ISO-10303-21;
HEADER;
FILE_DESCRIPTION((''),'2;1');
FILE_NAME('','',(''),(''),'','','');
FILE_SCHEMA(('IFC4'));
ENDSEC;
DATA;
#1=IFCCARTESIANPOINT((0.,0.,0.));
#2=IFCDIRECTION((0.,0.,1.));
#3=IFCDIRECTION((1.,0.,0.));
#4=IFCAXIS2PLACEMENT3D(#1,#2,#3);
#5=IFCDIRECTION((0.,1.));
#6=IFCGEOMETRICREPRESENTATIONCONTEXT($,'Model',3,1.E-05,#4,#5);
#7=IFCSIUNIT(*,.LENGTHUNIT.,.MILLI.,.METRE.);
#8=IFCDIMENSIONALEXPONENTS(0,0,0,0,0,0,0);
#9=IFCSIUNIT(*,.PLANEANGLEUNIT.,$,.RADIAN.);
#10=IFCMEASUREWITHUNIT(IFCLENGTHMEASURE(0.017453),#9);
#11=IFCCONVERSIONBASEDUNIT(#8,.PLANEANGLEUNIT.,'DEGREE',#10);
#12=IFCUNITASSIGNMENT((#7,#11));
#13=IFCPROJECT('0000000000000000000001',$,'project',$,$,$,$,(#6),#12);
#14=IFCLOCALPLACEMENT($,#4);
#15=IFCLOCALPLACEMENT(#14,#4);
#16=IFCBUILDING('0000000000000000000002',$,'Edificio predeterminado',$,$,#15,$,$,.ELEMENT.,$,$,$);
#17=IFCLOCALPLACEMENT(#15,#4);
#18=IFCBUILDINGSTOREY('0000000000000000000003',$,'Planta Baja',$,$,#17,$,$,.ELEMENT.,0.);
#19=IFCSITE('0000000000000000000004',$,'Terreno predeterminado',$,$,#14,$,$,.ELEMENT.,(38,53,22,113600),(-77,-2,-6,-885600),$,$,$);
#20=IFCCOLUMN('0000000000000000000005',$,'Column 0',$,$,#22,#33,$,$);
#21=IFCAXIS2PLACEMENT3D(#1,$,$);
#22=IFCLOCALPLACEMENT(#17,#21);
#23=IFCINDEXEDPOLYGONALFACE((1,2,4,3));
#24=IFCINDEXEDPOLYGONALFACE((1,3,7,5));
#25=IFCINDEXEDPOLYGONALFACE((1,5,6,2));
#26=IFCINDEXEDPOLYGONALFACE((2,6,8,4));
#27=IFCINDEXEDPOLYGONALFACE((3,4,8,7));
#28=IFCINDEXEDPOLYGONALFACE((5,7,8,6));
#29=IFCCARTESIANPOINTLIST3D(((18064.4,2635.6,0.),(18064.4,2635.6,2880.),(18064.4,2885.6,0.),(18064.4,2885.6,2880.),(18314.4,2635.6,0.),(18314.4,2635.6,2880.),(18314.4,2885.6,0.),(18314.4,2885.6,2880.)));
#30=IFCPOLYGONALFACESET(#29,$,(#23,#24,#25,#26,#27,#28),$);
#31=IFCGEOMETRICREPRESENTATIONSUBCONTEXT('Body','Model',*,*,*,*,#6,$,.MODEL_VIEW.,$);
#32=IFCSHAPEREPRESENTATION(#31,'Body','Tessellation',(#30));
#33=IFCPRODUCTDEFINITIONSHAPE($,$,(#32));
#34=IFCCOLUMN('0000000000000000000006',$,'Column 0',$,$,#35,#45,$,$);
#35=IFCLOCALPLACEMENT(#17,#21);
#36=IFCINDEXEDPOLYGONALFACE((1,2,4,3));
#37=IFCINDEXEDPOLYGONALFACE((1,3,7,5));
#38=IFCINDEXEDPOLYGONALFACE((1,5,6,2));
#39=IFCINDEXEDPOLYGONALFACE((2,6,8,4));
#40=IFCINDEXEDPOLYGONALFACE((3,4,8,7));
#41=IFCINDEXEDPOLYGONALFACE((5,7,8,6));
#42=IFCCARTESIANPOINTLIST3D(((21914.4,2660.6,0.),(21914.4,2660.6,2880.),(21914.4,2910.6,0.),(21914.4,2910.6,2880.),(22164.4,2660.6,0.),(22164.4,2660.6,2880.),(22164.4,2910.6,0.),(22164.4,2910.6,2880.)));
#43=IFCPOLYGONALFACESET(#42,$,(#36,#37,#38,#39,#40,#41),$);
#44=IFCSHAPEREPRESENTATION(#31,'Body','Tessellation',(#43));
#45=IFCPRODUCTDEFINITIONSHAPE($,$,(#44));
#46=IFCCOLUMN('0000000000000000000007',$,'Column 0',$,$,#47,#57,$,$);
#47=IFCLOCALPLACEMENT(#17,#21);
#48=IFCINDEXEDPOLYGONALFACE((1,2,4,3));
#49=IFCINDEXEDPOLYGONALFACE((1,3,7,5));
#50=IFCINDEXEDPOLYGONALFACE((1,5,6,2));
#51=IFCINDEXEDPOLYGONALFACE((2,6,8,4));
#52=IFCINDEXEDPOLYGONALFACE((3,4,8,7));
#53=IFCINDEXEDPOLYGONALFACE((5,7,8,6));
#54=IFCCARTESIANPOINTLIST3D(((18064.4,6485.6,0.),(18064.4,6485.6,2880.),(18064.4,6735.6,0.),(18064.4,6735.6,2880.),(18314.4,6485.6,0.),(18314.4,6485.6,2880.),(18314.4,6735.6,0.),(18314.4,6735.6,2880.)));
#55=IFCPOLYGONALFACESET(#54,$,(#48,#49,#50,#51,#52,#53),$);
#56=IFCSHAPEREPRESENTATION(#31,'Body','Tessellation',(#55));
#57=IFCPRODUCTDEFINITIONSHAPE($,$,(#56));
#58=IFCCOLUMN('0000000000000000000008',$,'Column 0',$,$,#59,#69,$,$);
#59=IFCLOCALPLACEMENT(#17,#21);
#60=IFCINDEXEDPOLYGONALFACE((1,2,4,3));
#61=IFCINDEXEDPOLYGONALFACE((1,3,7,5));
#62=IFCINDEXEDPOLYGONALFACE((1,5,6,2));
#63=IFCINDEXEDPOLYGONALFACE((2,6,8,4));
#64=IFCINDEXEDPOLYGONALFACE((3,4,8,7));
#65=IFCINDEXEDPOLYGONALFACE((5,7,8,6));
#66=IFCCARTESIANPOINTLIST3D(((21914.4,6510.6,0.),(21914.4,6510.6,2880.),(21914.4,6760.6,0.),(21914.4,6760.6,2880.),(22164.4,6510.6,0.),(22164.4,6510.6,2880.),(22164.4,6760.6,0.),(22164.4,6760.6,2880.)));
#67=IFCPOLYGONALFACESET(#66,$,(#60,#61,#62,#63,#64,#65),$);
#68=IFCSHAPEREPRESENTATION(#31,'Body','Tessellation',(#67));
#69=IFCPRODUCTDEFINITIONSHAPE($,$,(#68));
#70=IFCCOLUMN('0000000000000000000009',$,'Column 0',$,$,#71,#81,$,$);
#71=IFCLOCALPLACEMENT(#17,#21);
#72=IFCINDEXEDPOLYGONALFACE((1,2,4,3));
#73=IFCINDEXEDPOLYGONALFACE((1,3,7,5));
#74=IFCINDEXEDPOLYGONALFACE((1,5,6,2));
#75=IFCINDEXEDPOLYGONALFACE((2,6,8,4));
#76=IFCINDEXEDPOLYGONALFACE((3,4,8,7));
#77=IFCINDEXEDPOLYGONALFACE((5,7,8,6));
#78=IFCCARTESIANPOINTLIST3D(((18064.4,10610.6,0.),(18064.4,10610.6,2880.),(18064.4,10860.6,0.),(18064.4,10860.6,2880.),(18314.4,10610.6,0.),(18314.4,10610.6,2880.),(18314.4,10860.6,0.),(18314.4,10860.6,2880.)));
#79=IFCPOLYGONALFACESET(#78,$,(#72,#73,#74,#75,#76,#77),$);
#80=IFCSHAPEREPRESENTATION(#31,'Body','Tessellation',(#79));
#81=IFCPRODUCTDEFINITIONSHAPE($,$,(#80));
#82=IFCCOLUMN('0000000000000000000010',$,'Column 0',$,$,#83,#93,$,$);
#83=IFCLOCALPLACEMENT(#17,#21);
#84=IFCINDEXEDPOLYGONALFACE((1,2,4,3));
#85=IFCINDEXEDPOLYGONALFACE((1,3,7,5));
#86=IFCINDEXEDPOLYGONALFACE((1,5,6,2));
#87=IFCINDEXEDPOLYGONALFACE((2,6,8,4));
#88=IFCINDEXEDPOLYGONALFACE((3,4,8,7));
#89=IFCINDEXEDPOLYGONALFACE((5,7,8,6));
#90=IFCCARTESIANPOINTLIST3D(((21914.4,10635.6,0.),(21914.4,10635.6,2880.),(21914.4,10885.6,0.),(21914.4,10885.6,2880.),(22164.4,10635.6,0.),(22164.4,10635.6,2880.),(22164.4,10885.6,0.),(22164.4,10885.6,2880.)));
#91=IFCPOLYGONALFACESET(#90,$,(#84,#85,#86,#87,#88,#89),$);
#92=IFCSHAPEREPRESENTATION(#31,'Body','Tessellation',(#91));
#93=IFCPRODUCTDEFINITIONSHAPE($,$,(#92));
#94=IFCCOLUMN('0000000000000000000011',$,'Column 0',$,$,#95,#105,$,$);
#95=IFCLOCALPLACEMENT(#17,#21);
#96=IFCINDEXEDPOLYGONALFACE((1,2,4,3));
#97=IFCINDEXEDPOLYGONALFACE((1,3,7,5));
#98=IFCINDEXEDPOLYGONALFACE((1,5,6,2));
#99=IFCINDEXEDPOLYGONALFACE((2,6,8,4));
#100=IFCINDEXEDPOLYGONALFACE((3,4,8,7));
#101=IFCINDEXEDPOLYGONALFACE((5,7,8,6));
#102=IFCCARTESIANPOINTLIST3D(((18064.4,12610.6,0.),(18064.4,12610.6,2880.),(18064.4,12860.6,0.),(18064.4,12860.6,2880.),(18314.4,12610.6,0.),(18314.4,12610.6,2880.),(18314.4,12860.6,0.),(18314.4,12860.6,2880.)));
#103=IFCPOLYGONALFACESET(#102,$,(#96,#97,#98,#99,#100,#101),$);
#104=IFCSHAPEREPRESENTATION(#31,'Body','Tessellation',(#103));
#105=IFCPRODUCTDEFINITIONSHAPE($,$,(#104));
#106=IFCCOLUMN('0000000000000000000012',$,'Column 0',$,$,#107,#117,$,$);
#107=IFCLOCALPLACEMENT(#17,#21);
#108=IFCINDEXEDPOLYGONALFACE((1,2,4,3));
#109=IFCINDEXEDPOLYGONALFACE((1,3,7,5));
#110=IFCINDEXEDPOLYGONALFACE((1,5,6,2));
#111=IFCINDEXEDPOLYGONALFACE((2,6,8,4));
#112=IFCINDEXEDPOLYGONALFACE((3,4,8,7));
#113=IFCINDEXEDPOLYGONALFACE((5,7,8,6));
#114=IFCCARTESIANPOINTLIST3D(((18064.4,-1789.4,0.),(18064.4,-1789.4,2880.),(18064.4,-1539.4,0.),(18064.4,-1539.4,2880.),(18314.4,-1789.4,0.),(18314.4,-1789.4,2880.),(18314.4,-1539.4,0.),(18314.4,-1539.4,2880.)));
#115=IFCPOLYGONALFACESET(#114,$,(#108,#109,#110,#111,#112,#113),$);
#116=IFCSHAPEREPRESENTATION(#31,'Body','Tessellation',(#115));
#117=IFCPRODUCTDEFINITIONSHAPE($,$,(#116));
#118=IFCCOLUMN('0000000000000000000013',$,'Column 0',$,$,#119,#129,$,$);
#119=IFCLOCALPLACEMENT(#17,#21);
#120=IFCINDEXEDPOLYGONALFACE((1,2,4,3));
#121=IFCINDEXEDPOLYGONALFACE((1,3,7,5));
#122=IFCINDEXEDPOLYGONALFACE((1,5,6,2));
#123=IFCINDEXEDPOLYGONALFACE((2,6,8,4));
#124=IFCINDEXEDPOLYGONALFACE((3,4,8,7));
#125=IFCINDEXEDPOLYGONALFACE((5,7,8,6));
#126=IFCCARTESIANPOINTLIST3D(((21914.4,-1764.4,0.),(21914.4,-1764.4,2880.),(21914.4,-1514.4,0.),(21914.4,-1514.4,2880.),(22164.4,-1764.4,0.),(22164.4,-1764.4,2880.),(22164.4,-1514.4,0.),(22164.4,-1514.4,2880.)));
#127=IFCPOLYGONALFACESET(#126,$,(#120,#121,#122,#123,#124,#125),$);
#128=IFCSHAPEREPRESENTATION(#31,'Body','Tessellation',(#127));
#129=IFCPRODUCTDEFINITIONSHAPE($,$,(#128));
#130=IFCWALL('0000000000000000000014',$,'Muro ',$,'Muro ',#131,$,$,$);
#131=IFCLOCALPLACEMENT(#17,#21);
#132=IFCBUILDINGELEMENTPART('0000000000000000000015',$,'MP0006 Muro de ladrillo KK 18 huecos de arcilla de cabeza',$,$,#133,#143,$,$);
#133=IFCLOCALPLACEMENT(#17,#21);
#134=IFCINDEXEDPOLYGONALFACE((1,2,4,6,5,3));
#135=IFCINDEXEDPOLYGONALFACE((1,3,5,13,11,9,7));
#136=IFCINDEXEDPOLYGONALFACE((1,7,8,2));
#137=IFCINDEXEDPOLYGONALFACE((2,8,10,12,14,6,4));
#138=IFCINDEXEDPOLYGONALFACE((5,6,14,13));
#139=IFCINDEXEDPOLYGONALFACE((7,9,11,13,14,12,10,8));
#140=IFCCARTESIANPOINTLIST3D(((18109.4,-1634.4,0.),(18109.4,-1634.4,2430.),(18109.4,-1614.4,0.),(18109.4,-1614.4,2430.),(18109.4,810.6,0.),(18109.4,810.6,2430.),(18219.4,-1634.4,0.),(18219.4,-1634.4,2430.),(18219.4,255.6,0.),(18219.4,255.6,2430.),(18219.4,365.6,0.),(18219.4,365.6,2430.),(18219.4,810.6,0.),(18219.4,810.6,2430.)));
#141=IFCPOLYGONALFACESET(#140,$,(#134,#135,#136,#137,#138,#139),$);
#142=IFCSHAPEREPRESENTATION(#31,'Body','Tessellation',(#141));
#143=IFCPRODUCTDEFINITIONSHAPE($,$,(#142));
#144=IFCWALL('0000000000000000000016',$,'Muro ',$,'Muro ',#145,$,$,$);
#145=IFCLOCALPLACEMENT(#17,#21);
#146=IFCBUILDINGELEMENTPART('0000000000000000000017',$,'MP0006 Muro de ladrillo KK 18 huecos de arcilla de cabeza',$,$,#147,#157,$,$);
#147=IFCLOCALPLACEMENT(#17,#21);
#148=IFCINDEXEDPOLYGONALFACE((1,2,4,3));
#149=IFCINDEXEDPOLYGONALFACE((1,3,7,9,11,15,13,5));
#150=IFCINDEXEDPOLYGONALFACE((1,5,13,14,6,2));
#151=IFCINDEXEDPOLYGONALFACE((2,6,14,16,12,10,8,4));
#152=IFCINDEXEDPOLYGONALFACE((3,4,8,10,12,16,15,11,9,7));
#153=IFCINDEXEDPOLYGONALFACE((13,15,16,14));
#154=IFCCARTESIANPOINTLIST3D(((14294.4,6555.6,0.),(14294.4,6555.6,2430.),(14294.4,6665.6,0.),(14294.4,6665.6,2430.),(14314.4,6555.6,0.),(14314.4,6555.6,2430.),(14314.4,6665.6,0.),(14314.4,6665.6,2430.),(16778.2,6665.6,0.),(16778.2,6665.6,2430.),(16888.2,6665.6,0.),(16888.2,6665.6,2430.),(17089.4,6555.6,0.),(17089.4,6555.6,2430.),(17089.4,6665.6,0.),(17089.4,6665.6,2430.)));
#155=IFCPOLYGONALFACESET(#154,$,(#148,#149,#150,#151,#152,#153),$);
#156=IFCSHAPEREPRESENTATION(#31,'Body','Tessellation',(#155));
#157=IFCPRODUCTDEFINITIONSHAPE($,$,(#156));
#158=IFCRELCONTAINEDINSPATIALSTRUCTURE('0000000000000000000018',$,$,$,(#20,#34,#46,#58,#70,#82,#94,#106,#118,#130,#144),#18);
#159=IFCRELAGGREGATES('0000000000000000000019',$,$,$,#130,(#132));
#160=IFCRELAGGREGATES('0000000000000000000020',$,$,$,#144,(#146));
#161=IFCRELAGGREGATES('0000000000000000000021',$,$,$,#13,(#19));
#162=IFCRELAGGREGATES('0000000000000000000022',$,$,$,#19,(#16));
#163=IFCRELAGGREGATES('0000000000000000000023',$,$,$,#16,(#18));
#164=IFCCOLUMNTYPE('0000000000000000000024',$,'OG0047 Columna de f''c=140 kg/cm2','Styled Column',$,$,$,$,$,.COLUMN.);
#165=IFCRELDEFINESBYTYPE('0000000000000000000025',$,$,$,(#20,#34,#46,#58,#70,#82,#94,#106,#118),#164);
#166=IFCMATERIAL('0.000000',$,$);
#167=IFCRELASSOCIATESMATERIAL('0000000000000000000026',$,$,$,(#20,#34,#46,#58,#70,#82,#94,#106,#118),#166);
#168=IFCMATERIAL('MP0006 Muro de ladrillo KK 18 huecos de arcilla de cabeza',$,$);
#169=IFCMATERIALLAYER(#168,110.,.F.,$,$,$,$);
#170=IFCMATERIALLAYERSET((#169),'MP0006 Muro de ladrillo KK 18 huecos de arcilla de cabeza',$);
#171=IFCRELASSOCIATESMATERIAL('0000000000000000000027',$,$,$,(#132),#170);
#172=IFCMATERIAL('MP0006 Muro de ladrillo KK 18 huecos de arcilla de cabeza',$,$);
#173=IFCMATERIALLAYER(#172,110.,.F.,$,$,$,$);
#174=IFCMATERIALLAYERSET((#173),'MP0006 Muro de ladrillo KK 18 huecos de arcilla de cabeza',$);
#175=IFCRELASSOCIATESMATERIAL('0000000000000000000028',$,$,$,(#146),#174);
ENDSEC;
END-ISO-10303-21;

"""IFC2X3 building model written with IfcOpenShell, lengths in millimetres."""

from ifc_helpers import new_model, entity, si_unit, converted_unit, direction, frame, origin_with_axes, place, context, subcontext, project, spatial, polyline, outline, extrude, material, layer, layer_set, layer_usage, type_object, element, aggregate, save


model = new_model("IFC2X3")

# Units and contexts
model_context = context("Model", 3, precision=1e-05, world=origin_with_axes(), true_north=direction((0.0, 1.0)))
body_context = subcontext(model_context, "Body", "Model", "MODEL_VIEW")
ifc_project = project(units=[si_unit("LENGTHUNIT", "METRE", prefix="MILLI"), converted_unit("PLANEANGLEUNIT", "DEGREE", entity("IfcLengthMeasure", 0.017453), si_unit("PLANEANGLEUNIT", "RADIAN"), dimensions=[0, 0, 0, 0, 0, 0, 0])], contexts=[model_context])

# Site, building, storey
site_placement = place(None, origin_with_axes())
site = spatial("IfcSite", under=ifc_project, at=site_placement, Name="Terreno predeterminado", CompositionType="ELEMENT", RefLatitude=(38, 53, 22, 113600), RefLongitude=(-77, -2, -6, -885600))
building_placement = place(site_placement, origin_with_axes())
building = spatial("IfcBuilding", under=site, at=building_placement, Name="Edificio predeterminado", CompositionType="ELEMENT")
storey_placement = place(building_placement, origin_with_axes())
storey = spatial("IfcBuildingStorey", under=building, at=storey_placement, Name="Planta Baja", CompositionType="ELEMENT", Elevation=0.0)

# Columns
ifc_material_1 = material(Name="0.000000")
column_type = type_object("IfcColumnType", Name="OG0047 Columna de f'c=140 kg/cm2", Description="Styled Column", PredefinedType="COLUMN")
for number, where, z_axis, x_axis, name in (
    (1, (18189.4, 2760.6, 0.0), (0.0, 0.0, 1.0), (1.0, 0.0, 0.0), "Column 0"),
    (2, (22039.4, 2785.6, 0.0), (0.0, 0.0, 1.0), (1.0, 0.0, 0.0), "Column 0"),
    (3, (18189.4, 6610.6, 0.0), (0.0, 0.0, 1.0), (1.0, 0.0, 0.0), "Column 0"),
    (4, (22039.4, 6635.6, 0.0), (0.0, 0.0, 1.0), (1.0, 0.0, 0.0), "Column 0"),
    (5, (18189.4, 10735.6, 0.0), (0.0, 0.0, 1.0), (1.0, 0.0, 0.0), "Column 0"),
    (6, (22039.4, 10760.6, 0.0), (0.0, 0.0, 1.0), (1.0, 0.0, 0.0), "Column 0"),
    (7, (18189.4, 12735.6, 0.0), (0.0, 0.0, 1.0), (1.0, 0.0, 0.0), "Column 0"),
    (8, (18189.4, -1664.4, 0.0), (0.0, 0.0, 1.0), (1.0, 0.0, 0.0), "Column 0"),
    (9, (22039.4, -1639.4, 0.0), (0.0, 0.0, 1.0), (1.0, 0.0, 0.0), "Column 0"),
):
    element("IfcColumn", number, at=place(storey_placement, frame(where, z_axis=z_axis, x_axis=x_axis)), inside=storey, type_object=column_type, material=ifc_material_1, Name=name, context=body_context, shape_type="SweptSolid", body=[
        extrude(outline(polyline([(-125.0, -125.0), (125.0, -125.0), (125.0, 125.0), (-125.0, 125.0), (-125.0, -125.0)])), origin_with_axes(), (0.0, 0.0, 1.0), 2880.0),
    ])

# Walls, building element parts
wall_1_placement = place(storey_placement, frame((18164.4, 810.6, 0.0), z_axis=(0.0, 0.0, 1.0), x_axis=(0.0, -1.0, 0.0)))
wall_1 = element("IfcWall", 10, at=wall_1_placement, inside=storey, Name="Muro ", ObjectType="Muro ")
ifc_material_2 = material(Name="MP0006 Muro de ladrillo KK 18 huecos de arcilla de cabeza")
ifc_layer_1 = layer(ifc_material_2, 110.0, ventilated=False)
ifc_layer_set_1 = layer_set([ifc_layer_1], Name="MP0006 Muro de ladrillo KK 18 huecos de arcilla de cabeza")
ifc_layer_usage_1 = layer_usage(ifc_layer_set_1, "AXIS2", "NEGATIVE", -55.0)
building_element_part_1_placement = place(wall_1_placement, origin_with_axes())
building_element_part_1 = element("IfcBuildingElementPart", 11, at=building_element_part_1_placement, material=ifc_layer_usage_1, Name="MP0006 Muro de ladrillo KK 18 huecos de arcilla de cabeza", context=body_context, shape_type="SweptSolid", body=[
    extrude(outline(polyline([(2445.0, 55.0), (2445.0, -55.0), (2425.0, -55.0), (0.0, -55.0), (0.0, 55.0), (445.0, 55.0), (555.0, 55.0), (2445.0, 55.0)])), origin_with_axes(), (0.0, 0.0, 1.0), 2430.0),
])
aggregate(wall_1, [building_element_part_1])
wall_2_placement = place(storey_placement, frame((17089.4, 6610.6, 0.0), z_axis=(0.0, 0.0, 1.0), x_axis=(-1.0, 0.0, 0.0)))
wall_2 = element("IfcWall", 12, at=wall_2_placement, inside=storey, Name="Muro ", ObjectType="Muro ")
ifc_material_3 = material(Name="MP0006 Muro de ladrillo KK 18 huecos de arcilla de cabeza")
ifc_layer_2 = layer(ifc_material_3, 110.0, ventilated=False)
ifc_layer_set_2 = layer_set([ifc_layer_2], Name="MP0006 Muro de ladrillo KK 18 huecos de arcilla de cabeza")
ifc_layer_usage_2 = layer_usage(ifc_layer_set_2, "AXIS2", "NEGATIVE", -55.0)
building_element_part_2_placement = place(wall_2_placement, origin_with_axes())
building_element_part_2 = element("IfcBuildingElementPart", 13, at=building_element_part_2_placement, material=ifc_layer_usage_2, Name="MP0006 Muro de ladrillo KK 18 huecos de arcilla de cabeza", context=body_context, shape_type="SweptSolid", body=[
    extrude(outline(polyline([(0.0, 55.0), (2775.0, 55.0), (2795.0, 55.0), (2795.0, -55.0), (2775.0, -55.0), (311.1, -55.0), (201.1, -55.0), (0.0, -55.0), (0.0, 55.0)])), origin_with_axes(), (0.0, 0.0, 1.0), 2430.0),
])
aggregate(wall_2, [building_element_part_2])

save(model, "model.ifc")
